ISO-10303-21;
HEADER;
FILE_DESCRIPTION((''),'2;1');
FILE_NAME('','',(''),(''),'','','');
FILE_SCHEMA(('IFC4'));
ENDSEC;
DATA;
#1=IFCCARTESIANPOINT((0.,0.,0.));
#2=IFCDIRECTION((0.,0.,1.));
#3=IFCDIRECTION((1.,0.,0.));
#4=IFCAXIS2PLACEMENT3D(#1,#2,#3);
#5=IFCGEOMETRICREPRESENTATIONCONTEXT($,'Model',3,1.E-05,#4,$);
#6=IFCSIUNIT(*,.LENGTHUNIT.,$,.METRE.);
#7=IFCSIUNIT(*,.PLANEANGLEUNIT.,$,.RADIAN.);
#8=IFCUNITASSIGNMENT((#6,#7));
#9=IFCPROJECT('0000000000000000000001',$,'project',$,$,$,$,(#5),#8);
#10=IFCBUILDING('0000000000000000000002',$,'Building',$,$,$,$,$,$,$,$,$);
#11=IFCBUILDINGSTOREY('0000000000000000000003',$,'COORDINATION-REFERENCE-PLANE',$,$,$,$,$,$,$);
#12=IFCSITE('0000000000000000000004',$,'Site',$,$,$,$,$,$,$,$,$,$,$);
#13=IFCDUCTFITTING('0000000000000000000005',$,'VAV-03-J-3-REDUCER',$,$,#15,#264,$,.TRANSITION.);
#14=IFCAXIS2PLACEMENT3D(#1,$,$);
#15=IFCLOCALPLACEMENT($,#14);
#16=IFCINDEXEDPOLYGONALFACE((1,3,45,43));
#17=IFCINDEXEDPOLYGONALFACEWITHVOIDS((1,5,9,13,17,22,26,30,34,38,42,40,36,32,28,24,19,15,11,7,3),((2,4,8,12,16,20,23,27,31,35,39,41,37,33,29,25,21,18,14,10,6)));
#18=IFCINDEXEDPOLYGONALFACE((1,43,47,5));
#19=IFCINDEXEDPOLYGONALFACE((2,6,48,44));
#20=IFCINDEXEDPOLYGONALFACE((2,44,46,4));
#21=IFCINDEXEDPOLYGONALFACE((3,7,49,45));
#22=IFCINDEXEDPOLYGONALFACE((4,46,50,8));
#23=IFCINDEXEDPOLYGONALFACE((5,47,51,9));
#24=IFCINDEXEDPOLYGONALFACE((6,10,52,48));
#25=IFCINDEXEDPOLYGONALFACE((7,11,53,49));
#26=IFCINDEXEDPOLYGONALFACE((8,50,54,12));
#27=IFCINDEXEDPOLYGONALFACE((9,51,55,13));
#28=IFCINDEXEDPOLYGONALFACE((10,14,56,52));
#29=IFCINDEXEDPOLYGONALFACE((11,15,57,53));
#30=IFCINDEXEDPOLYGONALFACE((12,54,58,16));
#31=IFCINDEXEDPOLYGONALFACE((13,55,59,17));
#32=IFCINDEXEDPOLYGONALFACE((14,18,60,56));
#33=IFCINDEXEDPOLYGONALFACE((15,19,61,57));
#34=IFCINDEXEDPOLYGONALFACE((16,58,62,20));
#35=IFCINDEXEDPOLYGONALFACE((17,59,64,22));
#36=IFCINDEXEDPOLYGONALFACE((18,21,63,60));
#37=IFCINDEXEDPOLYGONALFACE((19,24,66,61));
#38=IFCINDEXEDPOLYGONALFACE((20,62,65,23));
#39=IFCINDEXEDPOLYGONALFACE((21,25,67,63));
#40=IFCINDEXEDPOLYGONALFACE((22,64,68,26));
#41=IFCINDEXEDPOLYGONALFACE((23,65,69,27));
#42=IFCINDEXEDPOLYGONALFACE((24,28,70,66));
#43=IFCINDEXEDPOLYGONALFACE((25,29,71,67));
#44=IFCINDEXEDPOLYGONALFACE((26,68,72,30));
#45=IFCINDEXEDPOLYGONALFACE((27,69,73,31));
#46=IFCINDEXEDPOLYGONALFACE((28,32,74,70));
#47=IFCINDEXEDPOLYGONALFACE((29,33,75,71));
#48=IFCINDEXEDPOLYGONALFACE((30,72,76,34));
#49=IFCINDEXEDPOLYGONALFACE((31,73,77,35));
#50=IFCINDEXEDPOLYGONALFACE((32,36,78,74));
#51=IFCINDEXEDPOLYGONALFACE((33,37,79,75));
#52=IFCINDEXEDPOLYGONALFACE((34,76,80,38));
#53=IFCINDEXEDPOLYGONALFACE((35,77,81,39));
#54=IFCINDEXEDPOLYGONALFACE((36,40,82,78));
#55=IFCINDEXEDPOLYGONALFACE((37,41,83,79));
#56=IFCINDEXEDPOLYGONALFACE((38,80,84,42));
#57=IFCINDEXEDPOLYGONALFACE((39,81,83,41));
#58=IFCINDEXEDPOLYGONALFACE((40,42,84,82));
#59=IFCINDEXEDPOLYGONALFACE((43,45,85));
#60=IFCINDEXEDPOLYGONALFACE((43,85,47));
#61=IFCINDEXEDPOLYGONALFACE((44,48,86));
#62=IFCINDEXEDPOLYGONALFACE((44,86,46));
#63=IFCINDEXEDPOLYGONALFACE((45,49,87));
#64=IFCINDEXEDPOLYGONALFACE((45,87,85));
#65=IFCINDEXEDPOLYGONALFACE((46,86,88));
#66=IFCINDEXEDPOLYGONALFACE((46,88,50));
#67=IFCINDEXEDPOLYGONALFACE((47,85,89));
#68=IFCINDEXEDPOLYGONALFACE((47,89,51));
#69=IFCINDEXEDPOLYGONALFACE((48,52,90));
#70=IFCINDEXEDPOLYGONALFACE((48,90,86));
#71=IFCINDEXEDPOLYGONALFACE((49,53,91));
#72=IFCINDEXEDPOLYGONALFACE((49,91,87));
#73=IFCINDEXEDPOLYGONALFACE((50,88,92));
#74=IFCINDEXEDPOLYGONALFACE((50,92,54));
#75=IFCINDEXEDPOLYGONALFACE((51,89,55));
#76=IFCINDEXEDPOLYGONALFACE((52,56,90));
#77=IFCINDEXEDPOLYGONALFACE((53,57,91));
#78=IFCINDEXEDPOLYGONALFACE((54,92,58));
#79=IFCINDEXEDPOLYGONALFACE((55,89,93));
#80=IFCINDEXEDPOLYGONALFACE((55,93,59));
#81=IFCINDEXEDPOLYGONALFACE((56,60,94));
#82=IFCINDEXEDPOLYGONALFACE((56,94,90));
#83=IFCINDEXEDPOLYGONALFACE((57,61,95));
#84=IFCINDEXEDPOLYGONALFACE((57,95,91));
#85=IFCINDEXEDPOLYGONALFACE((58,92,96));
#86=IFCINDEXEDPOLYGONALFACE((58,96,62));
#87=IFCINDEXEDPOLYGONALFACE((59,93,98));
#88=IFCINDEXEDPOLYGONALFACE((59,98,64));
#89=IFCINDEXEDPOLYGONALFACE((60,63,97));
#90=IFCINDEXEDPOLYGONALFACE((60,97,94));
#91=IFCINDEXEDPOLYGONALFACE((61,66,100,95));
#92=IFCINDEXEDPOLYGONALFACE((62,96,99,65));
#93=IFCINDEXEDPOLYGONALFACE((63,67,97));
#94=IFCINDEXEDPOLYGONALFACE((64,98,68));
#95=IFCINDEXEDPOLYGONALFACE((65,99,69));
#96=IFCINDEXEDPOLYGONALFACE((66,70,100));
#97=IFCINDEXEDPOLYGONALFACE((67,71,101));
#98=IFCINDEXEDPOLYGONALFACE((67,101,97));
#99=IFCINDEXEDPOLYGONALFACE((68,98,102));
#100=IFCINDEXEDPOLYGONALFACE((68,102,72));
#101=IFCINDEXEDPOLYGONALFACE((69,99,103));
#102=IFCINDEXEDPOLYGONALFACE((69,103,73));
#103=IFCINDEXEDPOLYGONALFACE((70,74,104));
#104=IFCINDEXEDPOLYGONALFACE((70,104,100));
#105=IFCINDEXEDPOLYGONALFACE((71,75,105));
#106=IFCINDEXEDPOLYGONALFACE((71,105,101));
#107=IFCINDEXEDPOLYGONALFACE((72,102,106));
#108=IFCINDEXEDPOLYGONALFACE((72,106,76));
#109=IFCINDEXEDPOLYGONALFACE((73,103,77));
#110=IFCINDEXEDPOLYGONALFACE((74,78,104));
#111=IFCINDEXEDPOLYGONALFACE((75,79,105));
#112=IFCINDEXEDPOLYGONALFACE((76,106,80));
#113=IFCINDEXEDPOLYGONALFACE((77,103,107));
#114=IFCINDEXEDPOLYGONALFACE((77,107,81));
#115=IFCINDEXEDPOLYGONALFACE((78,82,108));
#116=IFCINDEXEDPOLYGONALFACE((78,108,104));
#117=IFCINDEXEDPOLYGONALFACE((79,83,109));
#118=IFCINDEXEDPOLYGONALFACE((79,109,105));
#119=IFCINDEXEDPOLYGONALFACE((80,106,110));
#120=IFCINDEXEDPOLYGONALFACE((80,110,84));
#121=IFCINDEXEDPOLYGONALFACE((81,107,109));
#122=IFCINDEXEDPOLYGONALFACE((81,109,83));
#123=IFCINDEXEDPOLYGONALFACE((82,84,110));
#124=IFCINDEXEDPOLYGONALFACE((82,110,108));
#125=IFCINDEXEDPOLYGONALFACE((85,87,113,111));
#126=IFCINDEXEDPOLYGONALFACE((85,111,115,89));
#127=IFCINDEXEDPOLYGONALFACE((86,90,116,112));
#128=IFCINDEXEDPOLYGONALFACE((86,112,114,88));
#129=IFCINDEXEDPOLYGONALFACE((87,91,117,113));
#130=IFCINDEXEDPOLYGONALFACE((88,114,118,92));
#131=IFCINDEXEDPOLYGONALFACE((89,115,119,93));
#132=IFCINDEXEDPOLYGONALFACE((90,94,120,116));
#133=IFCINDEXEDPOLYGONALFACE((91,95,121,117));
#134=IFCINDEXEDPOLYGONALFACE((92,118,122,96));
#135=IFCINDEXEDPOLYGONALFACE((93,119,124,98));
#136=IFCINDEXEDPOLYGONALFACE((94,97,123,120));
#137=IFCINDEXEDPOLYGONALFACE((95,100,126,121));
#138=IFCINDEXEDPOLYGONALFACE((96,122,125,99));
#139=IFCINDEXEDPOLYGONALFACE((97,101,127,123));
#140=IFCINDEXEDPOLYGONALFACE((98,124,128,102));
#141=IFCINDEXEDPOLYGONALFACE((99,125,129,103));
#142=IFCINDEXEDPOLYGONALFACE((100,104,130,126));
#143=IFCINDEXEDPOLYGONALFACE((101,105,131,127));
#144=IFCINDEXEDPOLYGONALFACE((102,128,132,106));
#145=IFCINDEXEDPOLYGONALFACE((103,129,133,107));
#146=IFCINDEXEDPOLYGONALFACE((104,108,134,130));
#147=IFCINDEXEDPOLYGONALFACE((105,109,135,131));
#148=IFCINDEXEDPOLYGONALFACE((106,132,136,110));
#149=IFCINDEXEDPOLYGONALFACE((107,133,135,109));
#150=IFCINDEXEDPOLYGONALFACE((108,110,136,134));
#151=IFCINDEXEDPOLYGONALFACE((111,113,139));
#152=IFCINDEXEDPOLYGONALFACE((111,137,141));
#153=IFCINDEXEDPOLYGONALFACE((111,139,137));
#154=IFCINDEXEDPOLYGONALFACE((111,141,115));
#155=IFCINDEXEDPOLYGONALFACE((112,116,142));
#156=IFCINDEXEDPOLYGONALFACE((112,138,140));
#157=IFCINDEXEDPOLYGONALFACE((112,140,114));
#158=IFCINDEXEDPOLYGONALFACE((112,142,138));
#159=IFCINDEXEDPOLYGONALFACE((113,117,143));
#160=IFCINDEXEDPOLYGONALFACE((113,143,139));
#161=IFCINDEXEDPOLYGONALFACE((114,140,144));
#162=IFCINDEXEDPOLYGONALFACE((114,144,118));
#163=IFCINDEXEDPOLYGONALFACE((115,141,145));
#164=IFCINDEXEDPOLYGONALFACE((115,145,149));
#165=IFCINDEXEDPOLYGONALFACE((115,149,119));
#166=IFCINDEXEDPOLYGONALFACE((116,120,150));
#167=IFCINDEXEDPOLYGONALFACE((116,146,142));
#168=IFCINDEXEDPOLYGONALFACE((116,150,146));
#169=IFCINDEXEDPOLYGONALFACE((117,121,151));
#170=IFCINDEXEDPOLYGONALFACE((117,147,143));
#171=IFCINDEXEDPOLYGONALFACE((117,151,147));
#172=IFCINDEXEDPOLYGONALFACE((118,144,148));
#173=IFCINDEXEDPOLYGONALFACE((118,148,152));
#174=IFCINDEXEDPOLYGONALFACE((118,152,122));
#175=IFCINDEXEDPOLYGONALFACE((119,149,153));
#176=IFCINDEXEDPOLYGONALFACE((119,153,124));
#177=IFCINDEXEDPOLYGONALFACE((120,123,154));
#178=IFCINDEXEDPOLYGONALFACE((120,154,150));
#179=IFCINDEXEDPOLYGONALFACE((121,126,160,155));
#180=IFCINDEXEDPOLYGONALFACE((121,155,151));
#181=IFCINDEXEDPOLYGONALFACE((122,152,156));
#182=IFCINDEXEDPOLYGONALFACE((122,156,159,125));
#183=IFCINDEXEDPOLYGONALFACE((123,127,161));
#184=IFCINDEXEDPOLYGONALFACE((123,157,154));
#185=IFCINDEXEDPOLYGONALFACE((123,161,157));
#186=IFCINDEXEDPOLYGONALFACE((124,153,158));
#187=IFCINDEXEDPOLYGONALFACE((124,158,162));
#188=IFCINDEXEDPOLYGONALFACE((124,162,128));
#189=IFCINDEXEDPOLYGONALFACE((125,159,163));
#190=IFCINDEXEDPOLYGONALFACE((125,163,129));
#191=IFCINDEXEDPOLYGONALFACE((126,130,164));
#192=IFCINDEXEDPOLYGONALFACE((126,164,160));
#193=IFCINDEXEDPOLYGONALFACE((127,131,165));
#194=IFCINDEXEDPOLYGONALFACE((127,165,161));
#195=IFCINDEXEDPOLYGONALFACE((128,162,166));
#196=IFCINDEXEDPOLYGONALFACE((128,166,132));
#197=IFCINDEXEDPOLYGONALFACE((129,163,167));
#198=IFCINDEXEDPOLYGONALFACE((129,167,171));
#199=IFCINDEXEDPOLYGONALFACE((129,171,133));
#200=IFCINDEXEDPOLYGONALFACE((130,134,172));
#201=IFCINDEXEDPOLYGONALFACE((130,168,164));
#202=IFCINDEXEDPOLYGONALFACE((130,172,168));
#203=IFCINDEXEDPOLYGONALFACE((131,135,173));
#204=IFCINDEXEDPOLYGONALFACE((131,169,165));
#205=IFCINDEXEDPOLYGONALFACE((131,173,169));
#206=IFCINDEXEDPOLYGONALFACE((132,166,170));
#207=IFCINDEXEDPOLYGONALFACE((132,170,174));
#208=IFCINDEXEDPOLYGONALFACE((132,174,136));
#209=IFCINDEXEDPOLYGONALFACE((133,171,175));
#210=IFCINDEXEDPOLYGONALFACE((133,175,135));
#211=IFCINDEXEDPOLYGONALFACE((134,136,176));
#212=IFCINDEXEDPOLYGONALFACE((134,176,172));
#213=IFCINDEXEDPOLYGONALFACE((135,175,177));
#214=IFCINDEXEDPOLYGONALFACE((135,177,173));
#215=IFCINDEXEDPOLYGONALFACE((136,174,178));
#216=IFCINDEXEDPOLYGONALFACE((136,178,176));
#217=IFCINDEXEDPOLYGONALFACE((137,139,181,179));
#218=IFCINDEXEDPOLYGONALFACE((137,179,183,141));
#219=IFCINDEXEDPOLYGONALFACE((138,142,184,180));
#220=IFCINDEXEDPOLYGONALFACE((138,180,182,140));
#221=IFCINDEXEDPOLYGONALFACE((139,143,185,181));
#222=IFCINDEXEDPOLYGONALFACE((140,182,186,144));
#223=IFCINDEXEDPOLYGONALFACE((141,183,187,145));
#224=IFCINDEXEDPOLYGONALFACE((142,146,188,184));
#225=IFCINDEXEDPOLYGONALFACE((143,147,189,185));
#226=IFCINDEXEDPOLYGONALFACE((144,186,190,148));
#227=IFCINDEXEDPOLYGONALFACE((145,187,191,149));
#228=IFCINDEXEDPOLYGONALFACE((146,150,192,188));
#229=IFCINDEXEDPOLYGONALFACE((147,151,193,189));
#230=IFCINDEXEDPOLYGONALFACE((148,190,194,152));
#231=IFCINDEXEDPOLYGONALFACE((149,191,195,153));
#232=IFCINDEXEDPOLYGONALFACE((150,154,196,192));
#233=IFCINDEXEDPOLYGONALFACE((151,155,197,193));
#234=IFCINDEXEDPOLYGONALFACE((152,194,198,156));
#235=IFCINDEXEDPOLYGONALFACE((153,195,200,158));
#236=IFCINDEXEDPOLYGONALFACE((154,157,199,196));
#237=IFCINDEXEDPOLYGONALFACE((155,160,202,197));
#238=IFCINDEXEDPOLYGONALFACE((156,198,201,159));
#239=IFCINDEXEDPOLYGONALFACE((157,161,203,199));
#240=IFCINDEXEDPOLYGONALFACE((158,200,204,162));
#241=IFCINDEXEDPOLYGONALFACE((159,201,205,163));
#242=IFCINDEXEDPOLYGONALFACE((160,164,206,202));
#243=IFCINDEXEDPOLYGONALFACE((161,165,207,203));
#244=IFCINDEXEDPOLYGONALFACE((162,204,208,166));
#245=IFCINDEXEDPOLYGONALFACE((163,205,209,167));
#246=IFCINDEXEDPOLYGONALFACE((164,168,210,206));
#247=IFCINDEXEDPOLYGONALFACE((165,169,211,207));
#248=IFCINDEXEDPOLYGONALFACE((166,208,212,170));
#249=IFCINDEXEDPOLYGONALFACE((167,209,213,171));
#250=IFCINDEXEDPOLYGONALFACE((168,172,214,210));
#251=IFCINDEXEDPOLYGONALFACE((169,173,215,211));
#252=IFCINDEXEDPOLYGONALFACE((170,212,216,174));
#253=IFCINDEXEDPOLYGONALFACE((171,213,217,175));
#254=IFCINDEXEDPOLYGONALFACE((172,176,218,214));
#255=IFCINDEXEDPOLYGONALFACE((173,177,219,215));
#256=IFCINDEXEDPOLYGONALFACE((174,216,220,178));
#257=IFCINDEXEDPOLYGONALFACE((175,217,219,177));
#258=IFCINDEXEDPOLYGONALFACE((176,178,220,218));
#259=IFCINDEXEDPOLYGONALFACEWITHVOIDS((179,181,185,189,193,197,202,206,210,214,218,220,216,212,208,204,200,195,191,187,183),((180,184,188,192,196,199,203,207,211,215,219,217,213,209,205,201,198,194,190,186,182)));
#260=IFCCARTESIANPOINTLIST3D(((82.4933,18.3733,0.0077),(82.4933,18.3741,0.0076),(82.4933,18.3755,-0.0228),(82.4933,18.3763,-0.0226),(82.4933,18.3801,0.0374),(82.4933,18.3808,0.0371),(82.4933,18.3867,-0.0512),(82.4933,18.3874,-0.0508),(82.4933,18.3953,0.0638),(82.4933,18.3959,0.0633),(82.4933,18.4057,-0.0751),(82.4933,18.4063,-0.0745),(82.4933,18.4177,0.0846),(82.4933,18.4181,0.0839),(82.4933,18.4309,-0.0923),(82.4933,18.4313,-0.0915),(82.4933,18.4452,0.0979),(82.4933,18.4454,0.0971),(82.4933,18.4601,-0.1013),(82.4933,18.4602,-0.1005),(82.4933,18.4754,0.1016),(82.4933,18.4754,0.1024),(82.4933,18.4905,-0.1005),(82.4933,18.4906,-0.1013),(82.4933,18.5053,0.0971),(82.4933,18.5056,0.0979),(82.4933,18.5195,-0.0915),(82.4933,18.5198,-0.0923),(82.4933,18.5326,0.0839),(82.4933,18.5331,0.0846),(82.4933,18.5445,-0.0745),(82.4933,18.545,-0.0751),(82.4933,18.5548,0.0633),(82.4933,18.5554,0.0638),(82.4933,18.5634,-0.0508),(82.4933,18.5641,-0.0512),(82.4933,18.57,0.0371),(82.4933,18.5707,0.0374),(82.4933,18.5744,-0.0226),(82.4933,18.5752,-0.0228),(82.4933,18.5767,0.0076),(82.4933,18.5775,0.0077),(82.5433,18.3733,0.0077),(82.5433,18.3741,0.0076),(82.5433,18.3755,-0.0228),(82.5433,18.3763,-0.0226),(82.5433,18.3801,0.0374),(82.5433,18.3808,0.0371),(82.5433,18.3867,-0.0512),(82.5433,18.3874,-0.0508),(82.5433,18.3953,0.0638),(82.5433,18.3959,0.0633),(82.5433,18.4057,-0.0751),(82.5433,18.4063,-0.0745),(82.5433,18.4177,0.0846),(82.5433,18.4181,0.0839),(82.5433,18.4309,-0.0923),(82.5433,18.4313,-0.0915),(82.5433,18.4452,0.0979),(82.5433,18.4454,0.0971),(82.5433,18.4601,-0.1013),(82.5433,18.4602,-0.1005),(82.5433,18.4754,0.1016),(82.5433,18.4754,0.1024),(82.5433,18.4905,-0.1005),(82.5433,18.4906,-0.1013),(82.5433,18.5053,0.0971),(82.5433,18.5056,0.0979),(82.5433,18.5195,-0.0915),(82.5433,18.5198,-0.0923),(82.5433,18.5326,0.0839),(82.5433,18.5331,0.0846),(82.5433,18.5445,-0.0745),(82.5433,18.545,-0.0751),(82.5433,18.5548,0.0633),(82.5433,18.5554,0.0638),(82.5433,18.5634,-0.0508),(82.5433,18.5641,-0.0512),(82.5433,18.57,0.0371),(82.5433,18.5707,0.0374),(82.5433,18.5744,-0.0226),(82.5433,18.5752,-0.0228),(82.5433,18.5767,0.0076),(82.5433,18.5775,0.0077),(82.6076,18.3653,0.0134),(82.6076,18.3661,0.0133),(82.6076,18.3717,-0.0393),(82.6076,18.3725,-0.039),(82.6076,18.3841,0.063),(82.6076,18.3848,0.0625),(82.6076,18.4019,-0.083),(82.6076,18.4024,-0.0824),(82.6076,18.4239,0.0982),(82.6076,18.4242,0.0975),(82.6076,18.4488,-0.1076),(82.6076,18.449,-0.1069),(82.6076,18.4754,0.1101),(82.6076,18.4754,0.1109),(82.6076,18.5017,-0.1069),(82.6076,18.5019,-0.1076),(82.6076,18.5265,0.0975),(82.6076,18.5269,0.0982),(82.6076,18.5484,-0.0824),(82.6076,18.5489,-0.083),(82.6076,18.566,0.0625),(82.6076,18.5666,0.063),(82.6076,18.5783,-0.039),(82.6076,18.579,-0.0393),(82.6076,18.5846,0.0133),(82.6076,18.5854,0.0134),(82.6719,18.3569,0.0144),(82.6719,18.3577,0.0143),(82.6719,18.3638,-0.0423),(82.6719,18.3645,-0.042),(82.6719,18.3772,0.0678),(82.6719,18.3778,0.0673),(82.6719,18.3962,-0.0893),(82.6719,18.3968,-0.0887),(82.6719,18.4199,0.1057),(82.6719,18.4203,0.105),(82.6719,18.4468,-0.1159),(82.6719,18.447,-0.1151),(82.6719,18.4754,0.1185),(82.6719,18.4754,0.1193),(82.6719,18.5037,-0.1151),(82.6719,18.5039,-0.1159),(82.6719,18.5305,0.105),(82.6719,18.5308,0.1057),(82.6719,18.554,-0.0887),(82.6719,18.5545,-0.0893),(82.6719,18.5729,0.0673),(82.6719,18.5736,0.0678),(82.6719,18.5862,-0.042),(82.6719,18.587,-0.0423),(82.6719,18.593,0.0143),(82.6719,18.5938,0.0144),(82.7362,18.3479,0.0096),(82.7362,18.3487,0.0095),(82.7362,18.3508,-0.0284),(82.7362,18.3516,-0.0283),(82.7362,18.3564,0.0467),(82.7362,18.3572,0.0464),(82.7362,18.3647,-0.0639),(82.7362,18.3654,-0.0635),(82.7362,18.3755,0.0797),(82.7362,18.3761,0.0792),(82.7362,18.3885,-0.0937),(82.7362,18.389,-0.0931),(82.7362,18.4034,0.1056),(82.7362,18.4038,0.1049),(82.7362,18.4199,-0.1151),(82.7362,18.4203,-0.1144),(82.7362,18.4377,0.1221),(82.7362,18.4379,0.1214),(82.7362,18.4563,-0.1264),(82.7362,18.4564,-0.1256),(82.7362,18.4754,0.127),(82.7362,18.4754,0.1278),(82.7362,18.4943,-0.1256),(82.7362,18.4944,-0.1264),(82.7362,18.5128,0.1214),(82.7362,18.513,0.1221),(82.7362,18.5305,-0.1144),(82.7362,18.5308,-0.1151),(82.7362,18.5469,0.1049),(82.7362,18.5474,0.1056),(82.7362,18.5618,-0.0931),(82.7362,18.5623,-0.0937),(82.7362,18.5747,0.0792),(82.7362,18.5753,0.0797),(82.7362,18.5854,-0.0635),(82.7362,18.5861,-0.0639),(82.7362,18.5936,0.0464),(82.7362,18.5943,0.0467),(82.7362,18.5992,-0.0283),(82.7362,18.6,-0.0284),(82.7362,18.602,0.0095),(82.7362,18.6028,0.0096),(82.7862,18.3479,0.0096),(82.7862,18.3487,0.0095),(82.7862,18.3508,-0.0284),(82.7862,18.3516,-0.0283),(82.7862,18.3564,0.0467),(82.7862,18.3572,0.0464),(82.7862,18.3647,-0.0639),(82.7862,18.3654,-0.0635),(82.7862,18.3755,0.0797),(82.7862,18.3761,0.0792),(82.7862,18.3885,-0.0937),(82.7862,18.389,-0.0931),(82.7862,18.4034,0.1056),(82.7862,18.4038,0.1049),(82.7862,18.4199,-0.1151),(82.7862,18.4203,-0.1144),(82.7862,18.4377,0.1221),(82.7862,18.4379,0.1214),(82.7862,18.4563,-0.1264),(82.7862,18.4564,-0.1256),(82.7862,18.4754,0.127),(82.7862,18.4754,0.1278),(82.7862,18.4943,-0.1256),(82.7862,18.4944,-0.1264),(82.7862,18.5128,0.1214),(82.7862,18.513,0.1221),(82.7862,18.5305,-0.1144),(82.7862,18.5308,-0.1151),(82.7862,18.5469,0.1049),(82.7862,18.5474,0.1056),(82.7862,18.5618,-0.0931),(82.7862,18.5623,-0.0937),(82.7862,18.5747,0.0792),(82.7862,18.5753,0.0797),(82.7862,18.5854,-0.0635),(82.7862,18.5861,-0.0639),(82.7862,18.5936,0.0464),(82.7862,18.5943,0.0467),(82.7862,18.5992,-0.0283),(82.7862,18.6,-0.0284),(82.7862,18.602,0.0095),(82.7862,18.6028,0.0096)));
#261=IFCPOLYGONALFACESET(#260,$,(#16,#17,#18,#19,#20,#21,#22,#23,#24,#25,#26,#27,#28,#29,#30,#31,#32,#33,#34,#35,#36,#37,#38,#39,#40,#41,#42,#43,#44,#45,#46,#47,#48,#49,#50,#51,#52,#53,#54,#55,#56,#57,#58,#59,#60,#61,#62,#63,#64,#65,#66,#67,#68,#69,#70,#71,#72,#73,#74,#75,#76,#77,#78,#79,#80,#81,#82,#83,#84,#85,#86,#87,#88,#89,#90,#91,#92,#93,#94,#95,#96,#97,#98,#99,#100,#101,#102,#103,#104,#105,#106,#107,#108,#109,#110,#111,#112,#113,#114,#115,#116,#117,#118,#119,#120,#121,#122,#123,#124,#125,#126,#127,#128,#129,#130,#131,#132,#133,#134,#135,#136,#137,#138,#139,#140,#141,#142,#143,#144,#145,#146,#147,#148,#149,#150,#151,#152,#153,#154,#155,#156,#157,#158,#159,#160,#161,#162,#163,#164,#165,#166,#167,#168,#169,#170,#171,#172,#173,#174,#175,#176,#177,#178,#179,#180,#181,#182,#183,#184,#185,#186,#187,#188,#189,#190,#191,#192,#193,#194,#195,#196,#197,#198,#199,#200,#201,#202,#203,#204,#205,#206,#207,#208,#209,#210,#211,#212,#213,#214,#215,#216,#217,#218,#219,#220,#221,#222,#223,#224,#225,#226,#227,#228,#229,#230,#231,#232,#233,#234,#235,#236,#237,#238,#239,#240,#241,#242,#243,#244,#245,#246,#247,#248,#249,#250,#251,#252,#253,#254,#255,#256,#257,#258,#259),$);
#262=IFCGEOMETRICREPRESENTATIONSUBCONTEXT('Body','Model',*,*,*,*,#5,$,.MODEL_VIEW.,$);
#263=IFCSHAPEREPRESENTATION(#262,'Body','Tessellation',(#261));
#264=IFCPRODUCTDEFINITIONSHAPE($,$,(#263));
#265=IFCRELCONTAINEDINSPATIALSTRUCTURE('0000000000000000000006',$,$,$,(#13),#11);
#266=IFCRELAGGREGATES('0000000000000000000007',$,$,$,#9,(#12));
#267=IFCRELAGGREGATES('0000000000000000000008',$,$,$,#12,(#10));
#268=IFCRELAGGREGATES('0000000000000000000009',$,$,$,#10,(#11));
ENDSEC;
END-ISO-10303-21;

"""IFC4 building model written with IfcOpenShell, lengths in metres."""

from ifc_helpers import new_model, entity, si_unit, frame, origin_with_axes, place, context, subcontext, project, spatial, element, save


model = new_model("IFC4")

# Units and contexts
model_context_1 = context("Model", 3, precision=1e-05, world=origin_with_axes())
body_context_1 = subcontext(model_context_1, "Body", "Model", "MODEL_VIEW")
ifc_project = project(units=[si_unit("LENGTHUNIT", "METRE"), si_unit("PLANEANGLEUNIT", "RADIAN")], contexts=[model_context_1])

# Site, building, storey
site = spatial("IfcSite", under=ifc_project, Name="Site")
building = spatial("IfcBuilding", under=site, Name="Building")
storey = spatial("IfcBuildingStorey", under=building, Name="COORDINATION-REFERENCE-PLANE")

# Duct fitting
for number, where, z_axis, x_axis, name in (
    (1, (82.7862, 18.4754, 0.0), (0.0, -1.0, 0.0), (0.0, 0.0, 1.0), "VAV-03-J-3-REDUCER"),
):
    element("IfcDuctFitting", number, at=place(None, frame(where, z_axis=z_axis, x_axis=x_axis)), inside=storey, Name=name, PredefinedType="TRANSITION", context=body_context_1, shape_type="SweptSolid", body=[
        entity("IfcRevolvedAreaSolid", entity("IfcArbitraryClosedProfileDef", "AREA", None, entity("IfcPolyline", [entity("IfcCartesianPoint", [0.1278, 0.0]), entity("IfcCartesianPoint", [0.1278, 0.05]), entity("IfcCartesianPoint", [0.1024, 0.2429]), entity("IfcCartesianPoint", [0.1024, 0.2929]), entity("IfcCartesianPoint", [0.1016, 0.2929]), entity("IfcCartesianPoint", [0.1016, 0.2429]), entity("IfcCartesianPoint", [0.127, 0.05]), entity("IfcCartesianPoint", [0.127, 0.0]), entity("IfcCartesianPoint", [0.1278, 0.0])])), entity("IfcAxis2Placement3D", entity("IfcCartesianPoint", [0.0, 0.0, 0.0])), entity("IfcAxis1Placement", entity("IfcCartesianPoint", [0.0, 0.0, 0.0]), entity("IfcDirection", [0.0, 1.0, 0.0])), 6.283185),
    ])

save(model, "model.ifc")
